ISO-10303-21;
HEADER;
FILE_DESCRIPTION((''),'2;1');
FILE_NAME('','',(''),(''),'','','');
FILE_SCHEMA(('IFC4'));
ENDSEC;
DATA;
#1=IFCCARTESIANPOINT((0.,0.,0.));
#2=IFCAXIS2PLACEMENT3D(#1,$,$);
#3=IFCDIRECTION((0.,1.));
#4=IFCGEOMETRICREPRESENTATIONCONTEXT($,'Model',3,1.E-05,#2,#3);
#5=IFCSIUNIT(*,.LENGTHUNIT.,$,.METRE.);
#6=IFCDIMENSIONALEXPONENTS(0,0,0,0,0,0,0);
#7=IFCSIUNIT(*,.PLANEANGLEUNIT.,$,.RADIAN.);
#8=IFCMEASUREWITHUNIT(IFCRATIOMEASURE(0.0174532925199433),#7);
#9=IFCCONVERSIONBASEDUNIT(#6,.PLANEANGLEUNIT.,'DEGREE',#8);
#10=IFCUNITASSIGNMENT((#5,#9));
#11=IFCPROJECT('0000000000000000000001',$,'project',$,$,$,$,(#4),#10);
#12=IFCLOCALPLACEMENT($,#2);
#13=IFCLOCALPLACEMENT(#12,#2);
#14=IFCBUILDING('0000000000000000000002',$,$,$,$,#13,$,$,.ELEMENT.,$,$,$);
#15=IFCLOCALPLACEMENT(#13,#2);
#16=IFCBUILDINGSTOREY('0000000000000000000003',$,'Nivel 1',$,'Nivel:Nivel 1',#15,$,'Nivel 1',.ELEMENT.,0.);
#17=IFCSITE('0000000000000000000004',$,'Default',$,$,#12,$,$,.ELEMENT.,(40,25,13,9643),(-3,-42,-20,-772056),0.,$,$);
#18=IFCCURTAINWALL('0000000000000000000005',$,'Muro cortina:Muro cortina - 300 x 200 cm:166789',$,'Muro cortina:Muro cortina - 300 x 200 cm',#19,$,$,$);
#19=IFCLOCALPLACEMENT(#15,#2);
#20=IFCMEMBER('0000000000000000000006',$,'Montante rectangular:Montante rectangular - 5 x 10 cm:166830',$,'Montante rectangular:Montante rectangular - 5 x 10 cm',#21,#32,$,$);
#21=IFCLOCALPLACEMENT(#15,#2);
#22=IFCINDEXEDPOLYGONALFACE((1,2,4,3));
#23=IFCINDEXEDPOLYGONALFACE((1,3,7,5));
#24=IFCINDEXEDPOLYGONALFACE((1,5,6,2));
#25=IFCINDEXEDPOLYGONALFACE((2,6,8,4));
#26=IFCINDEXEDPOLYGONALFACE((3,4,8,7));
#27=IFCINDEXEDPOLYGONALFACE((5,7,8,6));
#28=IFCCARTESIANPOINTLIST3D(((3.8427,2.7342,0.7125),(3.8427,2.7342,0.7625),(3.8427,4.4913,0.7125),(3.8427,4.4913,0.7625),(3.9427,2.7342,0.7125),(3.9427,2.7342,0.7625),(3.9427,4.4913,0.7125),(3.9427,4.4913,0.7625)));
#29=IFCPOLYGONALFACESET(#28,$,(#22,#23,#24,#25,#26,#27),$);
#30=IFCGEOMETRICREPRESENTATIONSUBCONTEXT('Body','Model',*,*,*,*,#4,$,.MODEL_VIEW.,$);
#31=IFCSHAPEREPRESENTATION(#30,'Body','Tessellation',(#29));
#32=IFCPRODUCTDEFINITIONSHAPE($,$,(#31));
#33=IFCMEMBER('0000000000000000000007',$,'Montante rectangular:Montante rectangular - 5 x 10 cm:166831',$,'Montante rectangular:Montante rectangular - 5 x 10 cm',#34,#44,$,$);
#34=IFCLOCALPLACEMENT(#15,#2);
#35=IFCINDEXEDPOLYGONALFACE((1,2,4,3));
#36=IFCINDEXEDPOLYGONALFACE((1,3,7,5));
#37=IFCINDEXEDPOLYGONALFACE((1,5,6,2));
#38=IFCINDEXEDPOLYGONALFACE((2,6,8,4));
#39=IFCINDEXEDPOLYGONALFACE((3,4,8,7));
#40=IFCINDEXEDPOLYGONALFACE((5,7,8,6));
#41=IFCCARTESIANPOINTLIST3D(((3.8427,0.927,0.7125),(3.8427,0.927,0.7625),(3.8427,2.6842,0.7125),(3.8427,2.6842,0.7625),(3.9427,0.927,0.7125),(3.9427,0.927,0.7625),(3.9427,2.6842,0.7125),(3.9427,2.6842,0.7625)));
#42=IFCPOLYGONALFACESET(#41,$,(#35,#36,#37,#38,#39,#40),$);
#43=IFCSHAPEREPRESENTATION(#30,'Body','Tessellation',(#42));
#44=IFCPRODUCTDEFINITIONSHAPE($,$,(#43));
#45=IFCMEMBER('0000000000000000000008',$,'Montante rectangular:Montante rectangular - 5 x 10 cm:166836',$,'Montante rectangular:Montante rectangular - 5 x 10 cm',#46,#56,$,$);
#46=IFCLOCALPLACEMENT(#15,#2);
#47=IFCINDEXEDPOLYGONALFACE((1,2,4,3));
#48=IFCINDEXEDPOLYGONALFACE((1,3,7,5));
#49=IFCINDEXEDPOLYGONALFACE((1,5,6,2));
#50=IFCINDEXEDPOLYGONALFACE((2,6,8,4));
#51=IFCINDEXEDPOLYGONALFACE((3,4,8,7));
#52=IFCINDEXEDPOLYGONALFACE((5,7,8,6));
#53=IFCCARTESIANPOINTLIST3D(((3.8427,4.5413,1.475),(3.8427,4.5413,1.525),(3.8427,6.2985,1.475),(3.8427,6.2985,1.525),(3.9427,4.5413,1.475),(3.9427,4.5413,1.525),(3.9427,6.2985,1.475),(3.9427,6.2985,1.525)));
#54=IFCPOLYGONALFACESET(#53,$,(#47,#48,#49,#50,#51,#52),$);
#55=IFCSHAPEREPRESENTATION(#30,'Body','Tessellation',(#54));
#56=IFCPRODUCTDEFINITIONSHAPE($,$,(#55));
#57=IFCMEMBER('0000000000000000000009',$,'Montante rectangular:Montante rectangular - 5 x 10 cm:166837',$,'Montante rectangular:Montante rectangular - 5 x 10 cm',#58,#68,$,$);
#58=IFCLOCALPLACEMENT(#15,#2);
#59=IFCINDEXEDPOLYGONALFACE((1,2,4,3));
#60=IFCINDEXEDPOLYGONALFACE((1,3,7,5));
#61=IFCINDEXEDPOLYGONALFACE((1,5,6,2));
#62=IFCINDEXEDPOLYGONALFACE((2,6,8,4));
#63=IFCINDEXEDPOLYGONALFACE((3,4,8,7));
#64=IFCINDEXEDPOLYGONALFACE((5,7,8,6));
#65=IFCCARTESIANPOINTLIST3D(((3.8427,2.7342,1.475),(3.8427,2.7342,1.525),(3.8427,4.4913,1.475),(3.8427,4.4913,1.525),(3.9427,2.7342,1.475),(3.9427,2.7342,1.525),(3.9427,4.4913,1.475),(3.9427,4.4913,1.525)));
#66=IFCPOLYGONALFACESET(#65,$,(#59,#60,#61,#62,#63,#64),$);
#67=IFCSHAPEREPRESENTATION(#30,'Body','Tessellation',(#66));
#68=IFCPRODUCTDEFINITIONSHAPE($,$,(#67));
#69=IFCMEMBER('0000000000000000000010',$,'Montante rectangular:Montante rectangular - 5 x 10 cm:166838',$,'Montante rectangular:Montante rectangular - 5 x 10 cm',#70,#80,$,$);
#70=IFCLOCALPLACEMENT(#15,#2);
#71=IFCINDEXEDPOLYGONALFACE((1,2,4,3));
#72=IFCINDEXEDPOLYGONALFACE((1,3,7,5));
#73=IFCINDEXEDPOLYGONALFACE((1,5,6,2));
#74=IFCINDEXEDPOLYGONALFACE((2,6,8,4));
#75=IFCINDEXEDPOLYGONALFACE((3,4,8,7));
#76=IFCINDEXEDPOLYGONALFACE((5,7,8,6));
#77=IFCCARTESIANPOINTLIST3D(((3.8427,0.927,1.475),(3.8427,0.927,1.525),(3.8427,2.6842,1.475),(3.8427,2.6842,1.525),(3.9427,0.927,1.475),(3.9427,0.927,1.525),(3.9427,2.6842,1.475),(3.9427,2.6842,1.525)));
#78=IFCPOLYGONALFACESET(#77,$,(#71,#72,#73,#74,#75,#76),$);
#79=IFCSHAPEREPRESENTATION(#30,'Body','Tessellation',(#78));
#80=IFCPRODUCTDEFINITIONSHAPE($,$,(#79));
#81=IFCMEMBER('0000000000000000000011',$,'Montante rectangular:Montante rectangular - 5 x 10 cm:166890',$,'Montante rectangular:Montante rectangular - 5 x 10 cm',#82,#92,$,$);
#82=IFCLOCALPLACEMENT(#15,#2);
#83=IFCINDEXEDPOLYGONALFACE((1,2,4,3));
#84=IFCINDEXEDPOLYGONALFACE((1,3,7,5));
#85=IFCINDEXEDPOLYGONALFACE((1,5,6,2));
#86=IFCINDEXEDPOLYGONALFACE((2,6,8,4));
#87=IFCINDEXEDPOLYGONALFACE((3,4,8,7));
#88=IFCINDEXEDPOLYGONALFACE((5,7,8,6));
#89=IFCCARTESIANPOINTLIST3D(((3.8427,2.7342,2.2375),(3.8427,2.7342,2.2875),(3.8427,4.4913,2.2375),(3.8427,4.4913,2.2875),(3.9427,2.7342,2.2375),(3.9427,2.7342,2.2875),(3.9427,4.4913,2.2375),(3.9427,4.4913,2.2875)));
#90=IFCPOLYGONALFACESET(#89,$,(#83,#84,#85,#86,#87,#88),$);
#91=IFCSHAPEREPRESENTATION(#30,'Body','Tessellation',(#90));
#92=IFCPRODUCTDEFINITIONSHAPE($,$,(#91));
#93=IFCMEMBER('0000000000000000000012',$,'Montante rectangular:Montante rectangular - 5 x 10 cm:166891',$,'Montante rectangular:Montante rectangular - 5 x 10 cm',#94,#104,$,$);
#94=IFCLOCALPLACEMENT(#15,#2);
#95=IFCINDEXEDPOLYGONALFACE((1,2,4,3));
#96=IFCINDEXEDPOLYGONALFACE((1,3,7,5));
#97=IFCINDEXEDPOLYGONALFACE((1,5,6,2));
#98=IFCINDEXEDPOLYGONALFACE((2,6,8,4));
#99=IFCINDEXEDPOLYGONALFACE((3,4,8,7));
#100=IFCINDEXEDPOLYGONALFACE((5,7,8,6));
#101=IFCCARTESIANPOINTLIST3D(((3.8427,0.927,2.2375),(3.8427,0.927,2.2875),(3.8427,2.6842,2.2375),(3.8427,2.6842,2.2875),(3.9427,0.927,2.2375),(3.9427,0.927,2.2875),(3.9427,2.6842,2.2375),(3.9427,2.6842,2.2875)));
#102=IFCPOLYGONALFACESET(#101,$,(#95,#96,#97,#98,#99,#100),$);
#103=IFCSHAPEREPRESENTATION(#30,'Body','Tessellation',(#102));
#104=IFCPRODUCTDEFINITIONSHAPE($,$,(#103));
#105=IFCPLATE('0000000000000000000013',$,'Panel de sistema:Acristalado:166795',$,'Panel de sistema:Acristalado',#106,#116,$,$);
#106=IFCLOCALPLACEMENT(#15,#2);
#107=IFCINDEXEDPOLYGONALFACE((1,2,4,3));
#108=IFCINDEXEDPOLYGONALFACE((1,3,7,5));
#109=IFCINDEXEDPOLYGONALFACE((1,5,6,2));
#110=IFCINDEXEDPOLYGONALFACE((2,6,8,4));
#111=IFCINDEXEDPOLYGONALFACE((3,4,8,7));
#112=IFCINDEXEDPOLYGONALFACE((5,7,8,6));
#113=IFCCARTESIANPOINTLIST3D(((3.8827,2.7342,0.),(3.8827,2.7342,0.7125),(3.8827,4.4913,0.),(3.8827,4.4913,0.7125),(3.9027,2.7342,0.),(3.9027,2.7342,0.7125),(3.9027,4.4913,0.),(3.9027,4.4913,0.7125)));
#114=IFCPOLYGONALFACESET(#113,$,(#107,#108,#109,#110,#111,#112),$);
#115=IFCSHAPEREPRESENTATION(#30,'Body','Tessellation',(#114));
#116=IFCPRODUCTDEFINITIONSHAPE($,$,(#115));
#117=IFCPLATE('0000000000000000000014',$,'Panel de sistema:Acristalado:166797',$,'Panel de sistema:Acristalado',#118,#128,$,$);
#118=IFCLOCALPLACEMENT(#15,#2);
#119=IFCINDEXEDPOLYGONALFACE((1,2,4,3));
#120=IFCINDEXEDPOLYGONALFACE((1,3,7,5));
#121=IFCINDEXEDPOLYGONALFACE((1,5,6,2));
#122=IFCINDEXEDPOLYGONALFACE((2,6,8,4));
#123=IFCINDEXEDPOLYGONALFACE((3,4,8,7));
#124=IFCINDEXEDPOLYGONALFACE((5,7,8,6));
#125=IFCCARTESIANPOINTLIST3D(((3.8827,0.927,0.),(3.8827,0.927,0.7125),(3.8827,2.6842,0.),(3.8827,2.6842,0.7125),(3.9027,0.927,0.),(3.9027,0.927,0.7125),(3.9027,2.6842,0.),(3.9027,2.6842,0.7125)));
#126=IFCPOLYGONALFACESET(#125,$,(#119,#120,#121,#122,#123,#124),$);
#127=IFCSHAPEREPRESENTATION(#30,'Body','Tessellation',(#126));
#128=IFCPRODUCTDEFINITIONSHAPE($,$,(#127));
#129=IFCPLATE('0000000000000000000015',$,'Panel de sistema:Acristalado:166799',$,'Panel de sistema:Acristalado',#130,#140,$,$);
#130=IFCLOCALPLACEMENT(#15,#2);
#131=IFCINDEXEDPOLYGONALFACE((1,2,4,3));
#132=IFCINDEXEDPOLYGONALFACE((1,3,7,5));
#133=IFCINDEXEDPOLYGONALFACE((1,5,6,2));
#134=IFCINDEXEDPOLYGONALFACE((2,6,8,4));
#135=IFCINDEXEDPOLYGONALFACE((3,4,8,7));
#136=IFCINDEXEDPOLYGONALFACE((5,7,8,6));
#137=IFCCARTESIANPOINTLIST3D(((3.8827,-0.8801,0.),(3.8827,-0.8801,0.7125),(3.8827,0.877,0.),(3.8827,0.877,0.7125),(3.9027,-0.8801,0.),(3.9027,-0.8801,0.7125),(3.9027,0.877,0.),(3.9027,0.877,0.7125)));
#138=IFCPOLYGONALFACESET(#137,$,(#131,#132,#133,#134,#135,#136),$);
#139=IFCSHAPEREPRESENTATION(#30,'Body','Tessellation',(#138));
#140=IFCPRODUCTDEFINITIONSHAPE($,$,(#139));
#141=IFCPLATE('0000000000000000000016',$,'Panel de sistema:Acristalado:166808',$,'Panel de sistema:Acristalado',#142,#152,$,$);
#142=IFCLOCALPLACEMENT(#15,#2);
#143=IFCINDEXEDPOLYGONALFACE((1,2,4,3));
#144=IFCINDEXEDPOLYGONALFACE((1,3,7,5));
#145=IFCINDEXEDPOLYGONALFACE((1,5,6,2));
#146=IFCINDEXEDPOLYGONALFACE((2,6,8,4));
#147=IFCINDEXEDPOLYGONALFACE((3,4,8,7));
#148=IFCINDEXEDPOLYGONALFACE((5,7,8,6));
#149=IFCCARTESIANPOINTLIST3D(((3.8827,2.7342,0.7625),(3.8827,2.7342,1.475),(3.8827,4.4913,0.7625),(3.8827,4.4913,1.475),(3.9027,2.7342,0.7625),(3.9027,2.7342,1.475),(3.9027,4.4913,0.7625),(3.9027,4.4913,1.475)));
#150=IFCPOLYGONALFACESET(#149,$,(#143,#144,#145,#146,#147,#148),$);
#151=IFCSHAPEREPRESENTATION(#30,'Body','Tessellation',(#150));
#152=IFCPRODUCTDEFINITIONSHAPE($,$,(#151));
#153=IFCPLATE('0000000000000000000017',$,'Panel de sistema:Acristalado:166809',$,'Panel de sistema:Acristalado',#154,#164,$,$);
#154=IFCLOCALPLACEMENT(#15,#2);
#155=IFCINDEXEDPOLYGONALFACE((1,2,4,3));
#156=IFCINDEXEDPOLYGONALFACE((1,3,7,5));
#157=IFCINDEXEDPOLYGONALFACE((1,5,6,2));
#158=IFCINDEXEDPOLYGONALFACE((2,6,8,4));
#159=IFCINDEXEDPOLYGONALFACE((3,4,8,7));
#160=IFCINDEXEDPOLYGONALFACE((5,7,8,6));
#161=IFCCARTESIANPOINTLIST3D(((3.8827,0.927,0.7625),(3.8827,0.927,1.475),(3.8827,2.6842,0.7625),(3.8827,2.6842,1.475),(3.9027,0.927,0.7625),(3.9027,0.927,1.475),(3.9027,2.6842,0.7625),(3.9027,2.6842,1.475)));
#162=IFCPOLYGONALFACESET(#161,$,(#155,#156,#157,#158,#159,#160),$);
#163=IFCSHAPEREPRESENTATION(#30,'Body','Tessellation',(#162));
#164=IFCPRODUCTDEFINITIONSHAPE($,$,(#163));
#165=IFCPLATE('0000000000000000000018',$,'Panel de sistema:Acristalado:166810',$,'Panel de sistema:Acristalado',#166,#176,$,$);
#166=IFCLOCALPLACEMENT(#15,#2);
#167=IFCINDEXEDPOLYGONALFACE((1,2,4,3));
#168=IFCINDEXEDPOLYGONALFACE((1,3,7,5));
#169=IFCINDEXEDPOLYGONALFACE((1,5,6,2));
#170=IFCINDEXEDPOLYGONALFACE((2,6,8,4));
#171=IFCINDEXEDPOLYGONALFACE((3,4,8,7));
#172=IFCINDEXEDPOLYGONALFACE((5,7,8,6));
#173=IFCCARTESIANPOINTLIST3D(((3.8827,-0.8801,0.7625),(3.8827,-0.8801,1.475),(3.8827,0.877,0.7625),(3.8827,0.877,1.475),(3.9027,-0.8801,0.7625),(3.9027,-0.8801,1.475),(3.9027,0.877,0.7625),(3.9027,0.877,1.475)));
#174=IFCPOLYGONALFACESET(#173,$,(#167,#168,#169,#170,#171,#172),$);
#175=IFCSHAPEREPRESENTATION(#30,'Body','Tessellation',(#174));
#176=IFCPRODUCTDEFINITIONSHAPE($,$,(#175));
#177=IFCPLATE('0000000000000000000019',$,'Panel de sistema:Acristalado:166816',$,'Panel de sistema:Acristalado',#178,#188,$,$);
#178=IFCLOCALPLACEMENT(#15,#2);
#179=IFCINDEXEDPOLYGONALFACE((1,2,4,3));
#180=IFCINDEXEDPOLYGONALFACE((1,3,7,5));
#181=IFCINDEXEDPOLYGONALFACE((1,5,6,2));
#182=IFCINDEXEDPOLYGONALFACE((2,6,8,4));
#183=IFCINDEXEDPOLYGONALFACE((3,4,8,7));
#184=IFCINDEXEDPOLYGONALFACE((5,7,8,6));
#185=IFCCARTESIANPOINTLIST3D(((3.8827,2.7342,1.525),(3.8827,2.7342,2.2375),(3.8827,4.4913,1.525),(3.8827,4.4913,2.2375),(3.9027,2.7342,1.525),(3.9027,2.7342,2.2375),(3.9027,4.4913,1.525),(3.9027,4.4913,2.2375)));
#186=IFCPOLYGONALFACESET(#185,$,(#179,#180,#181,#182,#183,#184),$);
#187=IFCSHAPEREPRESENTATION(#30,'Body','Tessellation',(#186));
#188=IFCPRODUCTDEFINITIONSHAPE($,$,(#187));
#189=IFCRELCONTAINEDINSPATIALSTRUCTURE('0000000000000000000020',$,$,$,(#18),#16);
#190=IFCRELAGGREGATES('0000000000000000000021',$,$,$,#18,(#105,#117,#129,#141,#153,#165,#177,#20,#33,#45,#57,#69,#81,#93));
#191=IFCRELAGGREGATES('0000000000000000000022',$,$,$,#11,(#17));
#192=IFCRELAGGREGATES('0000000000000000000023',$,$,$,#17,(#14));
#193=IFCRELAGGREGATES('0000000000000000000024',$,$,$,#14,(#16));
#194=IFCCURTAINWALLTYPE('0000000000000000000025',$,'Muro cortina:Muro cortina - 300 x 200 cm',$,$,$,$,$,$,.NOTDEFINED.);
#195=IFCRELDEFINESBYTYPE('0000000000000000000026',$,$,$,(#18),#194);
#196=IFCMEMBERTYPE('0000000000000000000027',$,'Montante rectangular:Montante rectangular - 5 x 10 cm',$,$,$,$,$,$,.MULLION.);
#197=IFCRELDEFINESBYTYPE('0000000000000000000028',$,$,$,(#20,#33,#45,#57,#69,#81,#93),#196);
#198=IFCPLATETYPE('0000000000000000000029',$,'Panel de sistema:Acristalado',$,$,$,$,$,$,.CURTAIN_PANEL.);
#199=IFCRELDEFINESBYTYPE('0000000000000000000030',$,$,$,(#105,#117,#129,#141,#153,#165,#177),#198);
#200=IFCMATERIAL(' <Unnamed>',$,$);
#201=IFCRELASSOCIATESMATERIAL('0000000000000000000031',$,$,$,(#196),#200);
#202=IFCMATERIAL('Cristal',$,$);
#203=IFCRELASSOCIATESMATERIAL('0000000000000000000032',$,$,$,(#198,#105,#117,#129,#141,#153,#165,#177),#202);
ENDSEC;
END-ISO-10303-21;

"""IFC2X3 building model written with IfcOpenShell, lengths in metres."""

from ifc_helpers import new_model, entity, si_unit, converted_unit, direction, frame, origin, origin_2d_with_axis, place, context, subcontext, project, spatial, rectangle, extrude, source, transform, mapped, material, type_object, type_shapes, element, aggregate, save


model = new_model("IFC2X3")

# Units and contexts
model_context = context("Model", 3, precision=1e-05, world=origin(), true_north=direction((0.0, 1.0)))
body_context = subcontext(model_context, "Body", "Model", "MODEL_VIEW")
ifc_project = project(units=[si_unit("LENGTHUNIT", "METRE"), converted_unit("PLANEANGLEUNIT", "DEGREE", entity("IfcRatioMeasure", 0.0174532925199433), si_unit("PLANEANGLEUNIT", "RADIAN"), dimensions=[0, 0, 0, 0, 0, 0, 0])], contexts=[model_context])

# Site, building, storey
site_placement = place(None, origin())
site = spatial("IfcSite", under=ifc_project, at=site_placement, Name="Default", CompositionType="ELEMENT", RefLatitude=(40, 25, 13, 9643), RefLongitude=(-3, -42, -20, -772056), RefElevation=0.0)
building_placement = place(site_placement, origin())
building = spatial("IfcBuilding", under=site, at=building_placement, CompositionType="ELEMENT")
storey_placement = place(building_placement, origin())
storey = spatial("IfcBuildingStorey", under=building, at=storey_placement, Name="Nivel 1", ObjectType="Nivel:Nivel 1", LongName="Nivel 1", CompositionType="ELEMENT", Elevation=0.0)

# Curtain wall, members, plates
curtain_wall_type = type_object("IfcCurtainWallType", Name="Muro cortina:Muro cortina - 300 x 200 cm", PredefinedType="NOTDEFINED")
curtain_wall_placement = place(storey_placement, origin())
curtain_wall = element("IfcCurtainWall", 1, at=curtain_wall_placement, inside=storey, type_object=curtain_wall_type, Name="Muro cortina:Muro cortina - 300 x 200 cm:166789", ObjectType="Muro cortina:Muro cortina - 300 x 200 cm")
ifc_material_1 = material(Name=" <Unnamed>")
member_type_1 = type_object("IfcMemberType", Name="Montante rectangular:Montante rectangular - 5 x 10 cm", PredefinedType="MULLION", material=ifc_material_1)
shared_shape_1 = source(origin(), body_context, "Body", "SweptSolid", [
    extrude(rectangle(XDim=0.1, YDim=0.05, at=origin_2d_with_axis()), frame((0.0, 0.0, -1.7571), z_axis=(0.0, 0.0, 1.0), x_axis=(0.0, -1.0, 0.0)), (0.0, 0.0, 1.0), 1.7571),
])
type_shapes(member_type_1, [shared_shape_1])
member_1_placement = place(storey_placement, frame((3.8927, 2.7342, 0.7375), z_axis=(0.0, -1.0, 0.0), x_axis=(0.0, 0.0, 1.0)))
member_1 = element("IfcMember", 2, at=member_1_placement, type_object=member_type_1, Name="Montante rectangular:Montante rectangular - 5 x 10 cm:166830", ObjectType="Montante rectangular:Montante rectangular - 5 x 10 cm", context=body_context, shape_type="MappedRepresentation", body=[
    mapped(shared_shape_1, transform((0.0, 0.0, 0.0), scale=1.0)),
])
member_2_placement = place(storey_placement, frame((3.8927, 0.927, 0.7375), z_axis=(0.0, -1.0, 0.0), x_axis=(0.0, 0.0, 1.0)))
member_2 = element("IfcMember", 3, at=member_2_placement, type_object=member_type_1, Name="Montante rectangular:Montante rectangular - 5 x 10 cm:166831", ObjectType="Montante rectangular:Montante rectangular - 5 x 10 cm", context=body_context, shape_type="MappedRepresentation", body=[
    mapped(shared_shape_1, transform((0.0, 0.0, 0.0), scale=1.0)),
])
member_3_placement = place(storey_placement, frame((3.8927, 4.5413, 1.5), z_axis=(0.0, -1.0, 0.0), x_axis=(0.0, 0.0, 1.0)))
member_3 = element("IfcMember", 4, at=member_3_placement, type_object=member_type_1, Name="Montante rectangular:Montante rectangular - 5 x 10 cm:166836", ObjectType="Montante rectangular:Montante rectangular - 5 x 10 cm", context=body_context, shape_type="MappedRepresentation", body=[
    mapped(shared_shape_1, transform((0.0, 0.0, 0.0), scale=1.0)),
])
member_4_placement = place(storey_placement, frame((3.8927, 2.7342, 1.5), z_axis=(0.0, -1.0, 0.0), x_axis=(0.0, 0.0, 1.0)))
member_4 = element("IfcMember", 5, at=member_4_placement, type_object=member_type_1, Name="Montante rectangular:Montante rectangular - 5 x 10 cm:166837", ObjectType="Montante rectangular:Montante rectangular - 5 x 10 cm", context=body_context, shape_type="MappedRepresentation", body=[
    mapped(shared_shape_1, transform((0.0, 0.0, 0.0), scale=1.0)),
])
member_5_placement = place(storey_placement, frame((3.8927, 0.927, 1.5), z_axis=(0.0, -1.0, 0.0), x_axis=(0.0, 0.0, 1.0)))
member_5 = element("IfcMember", 6, at=member_5_placement, type_object=member_type_1, Name="Montante rectangular:Montante rectangular - 5 x 10 cm:166838", ObjectType="Montante rectangular:Montante rectangular - 5 x 10 cm", context=body_context, shape_type="MappedRepresentation", body=[
    mapped(shared_shape_1, transform((0.0, 0.0, 0.0), scale=1.0)),
])
member_6_placement = place(storey_placement, frame((3.8927, 2.7342, 2.2625), z_axis=(0.0, -1.0, 0.0), x_axis=(0.0, 0.0, 1.0)))
member_6 = element("IfcMember", 7, at=member_6_placement, type_object=member_type_1, Name="Montante rectangular:Montante rectangular - 5 x 10 cm:166890", ObjectType="Montante rectangular:Montante rectangular - 5 x 10 cm", context=body_context, shape_type="MappedRepresentation", body=[
    mapped(shared_shape_1, transform((0.0, 0.0, 0.0), scale=1.0)),
])
member_7_placement = place(storey_placement, frame((3.8927, 0.927, 2.2625), z_axis=(0.0, -1.0, 0.0), x_axis=(0.0, 0.0, 1.0)))
member_7 = element("IfcMember", 8, at=member_7_placement, type_object=member_type_1, Name="Montante rectangular:Montante rectangular - 5 x 10 cm:166891", ObjectType="Montante rectangular:Montante rectangular - 5 x 10 cm", context=body_context, shape_type="MappedRepresentation", body=[
    mapped(shared_shape_1, transform((0.0, 0.0, 0.0), scale=1.0)),
])
ifc_material_2 = material(Name="Cristal")
plate_type = type_object("IfcPlateType", Name="Panel de sistema:Acristalado", PredefinedType="CURTAIN_PANEL", material=ifc_material_2)
shared_shape_2 = source(origin(), body_context, "Body", "SweptSolid", [
    extrude(rectangle(XDim=0.02, YDim=1.7571, at=origin_2d_with_axis()), frame((0.0, 0.0, 0.0), z_axis=(0.0, 0.0, 1.0), x_axis=(0.0, 1.0, 0.0)), (0.0, 0.0, 1.0), 0.7125),
])
type_shapes(plate_type, [shared_shape_2])
plate_1_placement = place(curtain_wall_placement, frame((3.8927, 3.6127, 0.0), z_axis=(0.0, 0.0, 1.0), x_axis=(0.0, -1.0, 0.0)))
plate_1 = element("IfcPlate", 9, at=plate_1_placement, type_object=plate_type, material=ifc_material_2, Name="Panel de sistema:Acristalado:166795", ObjectType="Panel de sistema:Acristalado", context=body_context, shape_type="MappedRepresentation", body=[
    mapped(shared_shape_2, transform((0.0, 0.0, 0.0), scale=1.0)),
])
plate_2_placement = place(curtain_wall_placement, frame((3.8927, 1.8056, 0.0), z_axis=(0.0, 0.0, 1.0), x_axis=(0.0, -1.0, 0.0)))
plate_2 = element("IfcPlate", 10, at=plate_2_placement, type_object=plate_type, material=ifc_material_2, Name="Panel de sistema:Acristalado:166797", ObjectType="Panel de sistema:Acristalado", context=body_context, shape_type="MappedRepresentation", body=[
    mapped(shared_shape_2, transform((0.0, 0.0, 0.0), scale=1.0)),
])
plate_3_placement = place(curtain_wall_placement, frame((3.8927, -0.0015, 0.0), z_axis=(0.0, 0.0, 1.0), x_axis=(0.0, -1.0, 0.0)))
plate_3 = element("IfcPlate", 11, at=plate_3_placement, type_object=plate_type, material=ifc_material_2, Name="Panel de sistema:Acristalado:166799", ObjectType="Panel de sistema:Acristalado", context=body_context, shape_type="MappedRepresentation", body=[
    mapped(shared_shape_2, transform((0.0, 0.0, 0.0), scale=1.0)),
])
plate_4_placement = place(curtain_wall_placement, frame((3.8927, 3.6127, 0.7625), z_axis=(0.0, 0.0, 1.0), x_axis=(0.0, -1.0, 0.0)))
plate_4 = element("IfcPlate", 12, at=plate_4_placement, type_object=plate_type, material=ifc_material_2, Name="Panel de sistema:Acristalado:166808", ObjectType="Panel de sistema:Acristalado", context=body_context, shape_type="MappedRepresentation", body=[
    mapped(shared_shape_2, transform((0.0, 0.0, 0.0), scale=1.0)),
])
plate_5_placement = place(curtain_wall_placement, frame((3.8927, 1.8056, 0.7625), z_axis=(0.0, 0.0, 1.0), x_axis=(0.0, -1.0, 0.0)))
plate_5 = element("IfcPlate", 13, at=plate_5_placement, type_object=plate_type, material=ifc_material_2, Name="Panel de sistema:Acristalado:166809", ObjectType="Panel de sistema:Acristalado", context=body_context, shape_type="MappedRepresentation", body=[
    mapped(shared_shape_2, transform((0.0, 0.0, 0.0), scale=1.0)),
])
plate_6_placement = place(curtain_wall_placement, frame((3.8927, -0.0015, 0.7625), z_axis=(0.0, 0.0, 1.0), x_axis=(0.0, -1.0, 0.0)))
plate_6 = element("IfcPlate", 14, at=plate_6_placement, type_object=plate_type, material=ifc_material_2, Name="Panel de sistema:Acristalado:166810", ObjectType="Panel de sistema:Acristalado", context=body_context, shape_type="MappedRepresentation", body=[
    mapped(shared_shape_2, transform((0.0, 0.0, 0.0), scale=1.0)),
])
plate_7_placement = place(curtain_wall_placement, frame((3.8927, 3.6127, 1.525), z_axis=(0.0, 0.0, 1.0), x_axis=(0.0, -1.0, 0.0)))
plate_7 = element("IfcPlate", 15, at=plate_7_placement, type_object=plate_type, material=ifc_material_2, Name="Panel de sistema:Acristalado:166816", ObjectType="Panel de sistema:Acristalado", context=body_context, shape_type="MappedRepresentation", body=[
    mapped(shared_shape_2, transform((0.0, 0.0, 0.0), scale=1.0)),
])
aggregate(curtain_wall, [plate_1, plate_2, plate_3, plate_4, plate_5, plate_6, plate_7, member_1, member_2, member_3, member_4, member_5, member_6, member_7])

save(model, "model.ifc")
